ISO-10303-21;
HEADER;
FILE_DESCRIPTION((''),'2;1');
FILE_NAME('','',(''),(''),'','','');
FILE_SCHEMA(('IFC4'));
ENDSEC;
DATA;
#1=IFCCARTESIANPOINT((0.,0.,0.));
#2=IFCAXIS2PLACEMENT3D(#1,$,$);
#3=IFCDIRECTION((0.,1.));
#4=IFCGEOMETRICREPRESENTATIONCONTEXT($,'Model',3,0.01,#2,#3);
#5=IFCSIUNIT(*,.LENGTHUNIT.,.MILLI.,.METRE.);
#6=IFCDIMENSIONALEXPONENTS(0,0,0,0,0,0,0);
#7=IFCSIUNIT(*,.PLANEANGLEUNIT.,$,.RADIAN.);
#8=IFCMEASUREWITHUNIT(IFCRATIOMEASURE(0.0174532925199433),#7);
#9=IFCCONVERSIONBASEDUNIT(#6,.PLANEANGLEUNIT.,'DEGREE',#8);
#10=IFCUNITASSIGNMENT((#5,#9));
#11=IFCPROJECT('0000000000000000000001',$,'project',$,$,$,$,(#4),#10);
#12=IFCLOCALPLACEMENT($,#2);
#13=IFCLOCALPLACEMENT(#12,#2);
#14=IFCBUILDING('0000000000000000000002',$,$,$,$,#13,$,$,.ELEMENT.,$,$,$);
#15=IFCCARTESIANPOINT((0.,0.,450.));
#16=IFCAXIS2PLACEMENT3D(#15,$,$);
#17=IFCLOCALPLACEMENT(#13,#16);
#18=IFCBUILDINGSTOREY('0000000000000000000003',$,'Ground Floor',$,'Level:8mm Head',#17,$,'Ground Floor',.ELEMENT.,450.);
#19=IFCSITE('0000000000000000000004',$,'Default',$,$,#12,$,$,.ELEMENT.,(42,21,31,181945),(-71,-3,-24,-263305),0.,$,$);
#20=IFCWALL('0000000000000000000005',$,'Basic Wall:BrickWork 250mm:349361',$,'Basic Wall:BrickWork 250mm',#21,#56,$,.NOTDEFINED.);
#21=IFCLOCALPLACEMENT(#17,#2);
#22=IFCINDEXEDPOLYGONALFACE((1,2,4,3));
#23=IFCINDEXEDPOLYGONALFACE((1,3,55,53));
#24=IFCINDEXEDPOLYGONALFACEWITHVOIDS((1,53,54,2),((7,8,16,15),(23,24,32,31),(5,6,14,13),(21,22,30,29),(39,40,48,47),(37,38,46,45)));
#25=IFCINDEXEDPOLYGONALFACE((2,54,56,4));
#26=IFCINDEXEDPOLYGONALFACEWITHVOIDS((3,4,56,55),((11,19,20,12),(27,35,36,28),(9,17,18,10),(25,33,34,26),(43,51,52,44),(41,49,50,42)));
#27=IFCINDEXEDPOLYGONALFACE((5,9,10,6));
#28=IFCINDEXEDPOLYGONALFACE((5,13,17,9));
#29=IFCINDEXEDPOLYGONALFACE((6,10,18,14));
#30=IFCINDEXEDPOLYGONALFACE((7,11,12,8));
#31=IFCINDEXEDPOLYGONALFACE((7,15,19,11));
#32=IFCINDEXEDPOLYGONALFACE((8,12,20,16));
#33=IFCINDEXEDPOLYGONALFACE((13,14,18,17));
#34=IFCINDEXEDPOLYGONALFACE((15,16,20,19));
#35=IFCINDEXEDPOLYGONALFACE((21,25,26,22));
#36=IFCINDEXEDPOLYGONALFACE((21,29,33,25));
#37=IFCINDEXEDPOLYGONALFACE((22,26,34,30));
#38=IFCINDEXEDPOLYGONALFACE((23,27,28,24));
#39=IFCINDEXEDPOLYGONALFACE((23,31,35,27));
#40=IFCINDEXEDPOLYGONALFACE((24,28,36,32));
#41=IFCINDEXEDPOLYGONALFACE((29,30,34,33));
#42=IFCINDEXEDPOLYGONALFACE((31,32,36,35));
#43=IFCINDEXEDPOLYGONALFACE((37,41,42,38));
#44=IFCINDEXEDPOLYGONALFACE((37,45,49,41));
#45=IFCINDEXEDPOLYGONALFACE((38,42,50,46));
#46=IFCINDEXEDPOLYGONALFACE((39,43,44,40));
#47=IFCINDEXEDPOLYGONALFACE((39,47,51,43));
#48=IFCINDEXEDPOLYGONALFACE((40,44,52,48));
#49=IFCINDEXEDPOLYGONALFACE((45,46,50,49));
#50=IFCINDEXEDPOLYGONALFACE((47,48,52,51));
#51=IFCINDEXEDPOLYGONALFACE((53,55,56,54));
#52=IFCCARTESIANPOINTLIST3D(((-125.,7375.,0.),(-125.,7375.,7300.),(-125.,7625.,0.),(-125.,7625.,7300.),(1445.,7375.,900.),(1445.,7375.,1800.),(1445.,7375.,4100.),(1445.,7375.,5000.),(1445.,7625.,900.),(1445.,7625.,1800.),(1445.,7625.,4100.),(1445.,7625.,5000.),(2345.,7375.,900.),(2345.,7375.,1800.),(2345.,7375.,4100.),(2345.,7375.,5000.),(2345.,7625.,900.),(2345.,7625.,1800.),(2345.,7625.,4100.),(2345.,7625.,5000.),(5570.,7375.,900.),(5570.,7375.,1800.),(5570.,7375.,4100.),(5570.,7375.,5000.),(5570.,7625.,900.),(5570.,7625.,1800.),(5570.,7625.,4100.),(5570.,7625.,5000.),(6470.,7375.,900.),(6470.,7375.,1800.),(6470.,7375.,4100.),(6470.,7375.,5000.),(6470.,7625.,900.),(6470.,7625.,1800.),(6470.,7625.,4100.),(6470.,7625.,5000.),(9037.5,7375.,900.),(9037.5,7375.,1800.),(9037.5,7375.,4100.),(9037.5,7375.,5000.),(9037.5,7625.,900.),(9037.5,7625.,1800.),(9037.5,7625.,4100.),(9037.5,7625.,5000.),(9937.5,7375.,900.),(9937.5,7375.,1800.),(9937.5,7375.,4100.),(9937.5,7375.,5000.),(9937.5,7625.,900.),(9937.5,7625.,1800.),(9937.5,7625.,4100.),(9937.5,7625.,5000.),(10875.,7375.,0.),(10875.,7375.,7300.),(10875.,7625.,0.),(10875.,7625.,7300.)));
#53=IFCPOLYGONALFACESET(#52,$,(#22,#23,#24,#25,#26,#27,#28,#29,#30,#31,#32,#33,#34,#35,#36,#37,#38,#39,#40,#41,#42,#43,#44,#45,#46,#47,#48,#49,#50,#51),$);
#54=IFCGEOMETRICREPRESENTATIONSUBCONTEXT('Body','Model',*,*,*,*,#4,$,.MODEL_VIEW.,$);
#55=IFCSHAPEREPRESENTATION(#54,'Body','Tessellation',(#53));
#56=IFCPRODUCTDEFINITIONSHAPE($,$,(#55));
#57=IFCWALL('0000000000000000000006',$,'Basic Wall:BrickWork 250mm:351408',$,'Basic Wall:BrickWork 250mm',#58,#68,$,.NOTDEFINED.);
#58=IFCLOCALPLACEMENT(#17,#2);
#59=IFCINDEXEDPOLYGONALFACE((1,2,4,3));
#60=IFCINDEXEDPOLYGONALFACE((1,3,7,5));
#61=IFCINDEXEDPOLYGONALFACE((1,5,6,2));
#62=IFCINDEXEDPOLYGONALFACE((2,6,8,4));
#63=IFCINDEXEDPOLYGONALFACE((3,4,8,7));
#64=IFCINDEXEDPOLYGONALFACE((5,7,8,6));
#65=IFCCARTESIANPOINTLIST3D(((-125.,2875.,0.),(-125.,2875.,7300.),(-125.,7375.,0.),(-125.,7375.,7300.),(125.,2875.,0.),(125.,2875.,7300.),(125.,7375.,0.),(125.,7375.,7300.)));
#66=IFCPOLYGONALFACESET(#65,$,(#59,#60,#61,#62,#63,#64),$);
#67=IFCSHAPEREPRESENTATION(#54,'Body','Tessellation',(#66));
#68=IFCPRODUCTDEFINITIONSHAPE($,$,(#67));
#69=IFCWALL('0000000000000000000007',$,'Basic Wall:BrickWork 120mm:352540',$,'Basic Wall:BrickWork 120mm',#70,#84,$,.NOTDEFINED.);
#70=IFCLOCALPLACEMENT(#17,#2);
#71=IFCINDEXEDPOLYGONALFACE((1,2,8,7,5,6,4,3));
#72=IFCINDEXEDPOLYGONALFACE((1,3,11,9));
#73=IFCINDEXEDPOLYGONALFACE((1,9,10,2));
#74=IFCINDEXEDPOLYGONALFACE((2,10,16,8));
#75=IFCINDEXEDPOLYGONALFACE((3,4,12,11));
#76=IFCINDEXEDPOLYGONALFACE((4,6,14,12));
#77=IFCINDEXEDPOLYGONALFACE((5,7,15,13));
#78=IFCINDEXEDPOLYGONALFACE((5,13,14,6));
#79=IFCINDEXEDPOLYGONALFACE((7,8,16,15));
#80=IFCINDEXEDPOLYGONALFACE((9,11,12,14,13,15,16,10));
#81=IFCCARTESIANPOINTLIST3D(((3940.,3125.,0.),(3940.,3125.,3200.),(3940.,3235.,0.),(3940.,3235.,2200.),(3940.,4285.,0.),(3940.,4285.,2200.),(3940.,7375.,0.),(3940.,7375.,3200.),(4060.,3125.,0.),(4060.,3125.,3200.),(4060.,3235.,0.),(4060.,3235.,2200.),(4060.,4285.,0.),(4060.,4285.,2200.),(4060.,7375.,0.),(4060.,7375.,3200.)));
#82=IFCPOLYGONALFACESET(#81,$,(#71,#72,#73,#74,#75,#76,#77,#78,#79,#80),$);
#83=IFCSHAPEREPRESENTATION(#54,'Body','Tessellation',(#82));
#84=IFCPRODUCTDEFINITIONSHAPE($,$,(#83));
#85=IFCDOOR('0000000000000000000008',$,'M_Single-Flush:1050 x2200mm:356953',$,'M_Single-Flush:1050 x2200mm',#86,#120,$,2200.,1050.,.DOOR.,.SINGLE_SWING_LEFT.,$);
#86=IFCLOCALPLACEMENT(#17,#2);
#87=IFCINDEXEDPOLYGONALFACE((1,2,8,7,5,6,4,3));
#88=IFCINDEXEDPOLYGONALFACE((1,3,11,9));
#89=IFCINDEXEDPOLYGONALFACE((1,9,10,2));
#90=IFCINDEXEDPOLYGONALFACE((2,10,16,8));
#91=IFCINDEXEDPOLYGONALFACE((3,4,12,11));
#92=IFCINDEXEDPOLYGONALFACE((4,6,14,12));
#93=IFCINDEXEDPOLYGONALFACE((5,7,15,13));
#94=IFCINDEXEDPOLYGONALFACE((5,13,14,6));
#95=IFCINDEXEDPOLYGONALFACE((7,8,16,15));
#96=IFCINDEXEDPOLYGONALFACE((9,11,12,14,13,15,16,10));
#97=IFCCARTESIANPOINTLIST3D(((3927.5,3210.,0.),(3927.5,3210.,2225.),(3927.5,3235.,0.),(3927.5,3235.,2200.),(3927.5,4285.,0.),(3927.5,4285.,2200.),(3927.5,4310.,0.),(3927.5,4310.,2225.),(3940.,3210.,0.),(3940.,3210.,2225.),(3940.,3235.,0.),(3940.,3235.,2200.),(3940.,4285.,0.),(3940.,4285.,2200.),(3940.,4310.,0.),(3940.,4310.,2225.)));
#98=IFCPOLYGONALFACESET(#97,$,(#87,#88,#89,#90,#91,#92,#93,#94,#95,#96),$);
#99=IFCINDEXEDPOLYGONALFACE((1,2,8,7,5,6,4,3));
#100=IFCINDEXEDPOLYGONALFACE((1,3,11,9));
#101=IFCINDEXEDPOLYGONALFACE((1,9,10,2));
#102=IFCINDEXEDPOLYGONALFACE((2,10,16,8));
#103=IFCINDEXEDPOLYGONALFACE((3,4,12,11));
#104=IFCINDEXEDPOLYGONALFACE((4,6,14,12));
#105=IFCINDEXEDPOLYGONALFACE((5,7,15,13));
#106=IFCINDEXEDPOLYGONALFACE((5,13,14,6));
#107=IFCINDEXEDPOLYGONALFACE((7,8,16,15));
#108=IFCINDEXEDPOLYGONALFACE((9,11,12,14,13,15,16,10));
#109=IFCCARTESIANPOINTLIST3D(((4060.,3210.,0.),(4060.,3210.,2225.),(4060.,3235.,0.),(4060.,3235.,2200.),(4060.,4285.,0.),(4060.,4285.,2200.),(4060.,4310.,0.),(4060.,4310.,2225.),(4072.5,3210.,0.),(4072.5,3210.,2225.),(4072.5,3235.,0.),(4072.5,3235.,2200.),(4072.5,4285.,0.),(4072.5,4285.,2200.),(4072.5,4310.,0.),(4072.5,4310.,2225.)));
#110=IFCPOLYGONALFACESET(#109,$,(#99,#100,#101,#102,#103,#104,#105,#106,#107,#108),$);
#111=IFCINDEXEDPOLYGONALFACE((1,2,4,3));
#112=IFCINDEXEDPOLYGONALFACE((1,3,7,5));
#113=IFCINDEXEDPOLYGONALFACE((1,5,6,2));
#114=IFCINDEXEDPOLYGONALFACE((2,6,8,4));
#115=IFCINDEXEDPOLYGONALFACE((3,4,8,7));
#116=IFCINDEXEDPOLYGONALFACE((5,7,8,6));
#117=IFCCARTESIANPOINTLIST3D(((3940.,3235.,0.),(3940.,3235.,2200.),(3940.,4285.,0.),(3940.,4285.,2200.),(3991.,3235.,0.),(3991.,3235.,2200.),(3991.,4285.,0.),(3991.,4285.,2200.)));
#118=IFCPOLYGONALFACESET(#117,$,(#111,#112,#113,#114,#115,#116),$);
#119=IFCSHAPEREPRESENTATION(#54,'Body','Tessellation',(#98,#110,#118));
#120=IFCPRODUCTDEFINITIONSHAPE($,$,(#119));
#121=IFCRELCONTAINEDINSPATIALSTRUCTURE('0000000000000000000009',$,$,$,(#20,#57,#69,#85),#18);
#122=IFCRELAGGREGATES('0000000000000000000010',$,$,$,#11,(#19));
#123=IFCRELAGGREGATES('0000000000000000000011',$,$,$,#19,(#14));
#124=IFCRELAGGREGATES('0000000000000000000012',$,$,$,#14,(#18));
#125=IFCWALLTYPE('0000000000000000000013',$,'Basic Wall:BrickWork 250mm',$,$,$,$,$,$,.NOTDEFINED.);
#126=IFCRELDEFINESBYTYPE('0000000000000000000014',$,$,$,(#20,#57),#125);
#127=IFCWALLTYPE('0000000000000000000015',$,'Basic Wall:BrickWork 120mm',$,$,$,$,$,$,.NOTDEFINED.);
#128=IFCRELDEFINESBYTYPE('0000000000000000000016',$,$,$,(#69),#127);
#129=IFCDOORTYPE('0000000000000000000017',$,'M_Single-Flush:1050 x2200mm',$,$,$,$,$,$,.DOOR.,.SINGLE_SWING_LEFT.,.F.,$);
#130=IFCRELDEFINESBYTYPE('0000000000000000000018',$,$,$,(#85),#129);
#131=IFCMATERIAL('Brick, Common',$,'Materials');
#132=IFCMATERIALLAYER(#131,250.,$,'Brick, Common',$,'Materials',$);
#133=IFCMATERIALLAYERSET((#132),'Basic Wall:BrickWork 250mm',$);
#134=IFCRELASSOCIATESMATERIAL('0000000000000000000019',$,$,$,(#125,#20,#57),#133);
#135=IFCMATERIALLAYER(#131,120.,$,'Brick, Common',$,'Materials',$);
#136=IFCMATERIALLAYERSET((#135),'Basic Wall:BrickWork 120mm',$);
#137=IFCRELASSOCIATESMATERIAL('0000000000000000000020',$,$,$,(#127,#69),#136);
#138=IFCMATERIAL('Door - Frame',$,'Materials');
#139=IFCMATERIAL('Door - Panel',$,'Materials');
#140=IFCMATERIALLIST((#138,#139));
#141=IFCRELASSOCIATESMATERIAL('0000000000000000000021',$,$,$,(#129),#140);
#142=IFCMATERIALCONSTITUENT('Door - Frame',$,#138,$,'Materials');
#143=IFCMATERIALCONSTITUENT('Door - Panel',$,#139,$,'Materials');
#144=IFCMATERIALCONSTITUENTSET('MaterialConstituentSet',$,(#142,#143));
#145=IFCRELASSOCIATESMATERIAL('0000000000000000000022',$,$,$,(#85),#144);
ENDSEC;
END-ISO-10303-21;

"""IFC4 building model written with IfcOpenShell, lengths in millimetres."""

from ifc_helpers import new_model, entity, si_unit, converted_unit, direction, frame, frame_2d, origin, place, context, subcontext, project, spatial, polyline, rectangle, outline, extrude, source, transform, mapped, material, material_list, layer, layer_set, layer_usage, constituent, constituent_set, type_object, type_shapes, element, fill, save


model = new_model("IFC4")

# Units and contexts
model_context = context("Model", 3, precision=0.01, world=origin(), true_north=direction((0.0, 1.0)))
body_context = subcontext(model_context, "Body", "Model", "MODEL_VIEW")
ifc_project = project(units=[si_unit("LENGTHUNIT", "METRE", prefix="MILLI"), converted_unit("PLANEANGLEUNIT", "DEGREE", entity("IfcRatioMeasure", 0.0174532925199433), si_unit("PLANEANGLEUNIT", "RADIAN"), dimensions=[0, 0, 0, 0, 0, 0, 0])], contexts=[model_context])

# Site, building, storey
site_placement = place(None, origin())
site = spatial("IfcSite", under=ifc_project, at=site_placement, Name="Default", CompositionType="ELEMENT", RefLatitude=(42, 21, 31, 181945), RefLongitude=(-71, -3, -24, -263305), RefElevation=0.0)
building_placement = place(site_placement, origin())
building = spatial("IfcBuilding", under=site, at=building_placement, CompositionType="ELEMENT")
storey_placement = place(building_placement, frame((0.0, 0.0, 450.0)))
storey = spatial("IfcBuildingStorey", under=building, at=storey_placement, Name="Ground Floor", ObjectType="Level:8mm Head", LongName="Ground Floor", CompositionType="ELEMENT", Elevation=450.0)

# Wall, openings
ifc_material_1 = material(Name="Brick, Common", Category="Materials")
ifc_layer_1 = layer(ifc_material_1, 250.0, Name="Brick, Common", Category="Materials")
ifc_layer_set_1 = layer_set([ifc_layer_1], Name="Basic Wall:BrickWork 250mm")
ifc_layer_usage_1 = layer_usage(ifc_layer_set_1, "AXIS2", "POSITIVE", -125.0)
wall_type_1 = type_object("IfcWallType", Name="Basic Wall:BrickWork 250mm", PredefinedType="NOTDEFINED", material=ifc_layer_set_1)
wall_1_placement = place(storey_placement, frame((-125.0, 7500.0, 0.0)))
wall_1 = element("IfcWall", 1, at=wall_1_placement, inside=storey, type_object=wall_type_1, material=ifc_layer_usage_1, Name="Basic Wall:BrickWork 250mm:349361", ObjectType="Basic Wall:BrickWork 250mm", PredefinedType="NOTDEFINED", context=body_context, shape_type="SweptSolid", body=[
    extrude(rectangle(XDim=11000.0, YDim=250.0, at=frame_2d((5500.0, 0.0), x_axis=(-1.0, 0.0))), origin(), (0.0, 0.0, 1.0), 7300.0),
])
opening_1_placement = place(wall_1_placement, frame((2470.0, 125.0, 900.0)))
element("IfcOpeningElement", 2, at=opening_1_placement, cuts=wall_1, ObjectType="Opening", PredefinedType="OPENING", context=body_context, shape_type="SweptSolid", body=[
    extrude(rectangle(XDim=900.0, YDim=900.0, at=frame_2d((450.0, 450.0), x_axis=(-1.0, 0.0))), frame((0.0, 0.0, 0.0), z_axis=(0.0, -1.0, 0.0), x_axis=(0.0, 0.0, 1.0)), (0.0, 0.0, 1.0), 250.0),
])
opening_2_placement = place(wall_1_placement, frame((6595.0, 125.0, 900.0)))
element("IfcOpeningElement", 3, at=opening_2_placement, cuts=wall_1, ObjectType="Opening", PredefinedType="OPENING", context=body_context, shape_type="SweptSolid", body=[
    extrude(rectangle(XDim=900.0, YDim=900.0, at=frame_2d((450.0, 450.0), x_axis=(-1.0, 0.0))), frame((0.0, 0.0, 0.0), z_axis=(0.0, -1.0, 0.0), x_axis=(0.0, 0.0, 1.0)), (0.0, 0.0, 1.0), 250.0),
])
opening_3_placement = place(wall_1_placement, frame((10062.5, 125.0, 900.0)))
element("IfcOpeningElement", 4, at=opening_3_placement, cuts=wall_1, ObjectType="Opening", PredefinedType="OPENING", context=body_context, shape_type="SweptSolid", body=[
    extrude(rectangle(XDim=900.0, YDim=900.0, at=frame_2d((450.0, 450.0), x_axis=(-1.0, 0.0))), frame((0.0, 0.0, 0.0), z_axis=(0.0, -1.0, 0.0), x_axis=(0.0, 0.0, 1.0)), (0.0, 0.0, 1.0), 250.0),
])
opening_4_placement = place(wall_1_placement, frame((2470.0, 125.0, 4100.0)))
element("IfcOpeningElement", 5, at=opening_4_placement, cuts=wall_1, ObjectType="Opening", PredefinedType="OPENING", context=body_context, shape_type="SweptSolid", body=[
    extrude(rectangle(XDim=900.0, YDim=900.0, at=frame_2d((450.0, 450.0), x_axis=(-1.0, 0.0))), frame((0.0, 0.0, 0.0), z_axis=(0.0, -1.0, 0.0), x_axis=(0.0, 0.0, 1.0)), (0.0, 0.0, 1.0), 250.0),
])
opening_5_placement = place(wall_1_placement, frame((6595.0, 125.0, 4100.0)))
element("IfcOpeningElement", 6, at=opening_5_placement, cuts=wall_1, ObjectType="Opening", PredefinedType="OPENING", context=body_context, shape_type="SweptSolid", body=[
    extrude(rectangle(XDim=900.0, YDim=900.0, at=frame_2d((450.0, 450.0), x_axis=(-1.0, 0.0))), frame((0.0, 0.0, 0.0), z_axis=(0.0, -1.0, 0.0), x_axis=(0.0, 0.0, 1.0)), (0.0, 0.0, 1.0), 250.0),
])
opening_6_placement = place(wall_1_placement, frame((10062.5, 125.0, 4100.0)))
element("IfcOpeningElement", 7, at=opening_6_placement, cuts=wall_1, ObjectType="Opening", PredefinedType="OPENING", context=body_context, shape_type="SweptSolid", body=[
    extrude(rectangle(XDim=900.0, YDim=900.0, at=frame_2d((450.0, 450.0), x_axis=(-1.0, 0.0))), frame((0.0, 0.0, 0.0), z_axis=(0.0, -1.0, 0.0), x_axis=(0.0, 0.0, 1.0)), (0.0, 0.0, 1.0), 250.0),
])

# Wall
ifc_layer_usage_2 = layer_usage(ifc_layer_set_1, "AXIS2", "POSITIVE", -125.0)
wall_2_placement = place(storey_placement, frame((0.0, 7375.0, 0.0), z_axis=(0.0, 0.0, 1.0), x_axis=(0.0, -1.0, 0.0)))
element("IfcWall", 8, at=wall_2_placement, inside=storey, type_object=wall_type_1, material=ifc_layer_usage_2, Name="Basic Wall:BrickWork 250mm:351408", ObjectType="Basic Wall:BrickWork 250mm", PredefinedType="NOTDEFINED", context=body_context, shape_type="SweptSolid", body=[
    extrude(rectangle(XDim=4500.0, YDim=250.0, at=frame_2d((2250.0, 0.0), x_axis=(-1.0, 0.0))), origin(), (0.0, 0.0, 1.0), 7300.0),
])

# Wall, opening, door
ifc_layer_2 = layer(ifc_material_1, 120.0, Name="Brick, Common", Category="Materials")
ifc_layer_set_2 = layer_set([ifc_layer_2], Name="Basic Wall:BrickWork 120mm")
ifc_layer_usage_3 = layer_usage(ifc_layer_set_2, "AXIS2", "NEGATIVE", 60.0)
wall_type_2 = type_object("IfcWallType", Name="Basic Wall:BrickWork 120mm", PredefinedType="NOTDEFINED", material=ifc_layer_set_2)
wall_3_placement = place(storey_placement, frame((4000.0, 7375.0, 0.0), z_axis=(0.0, 0.0, 1.0), x_axis=(0.0, -1.0, 0.0)))
wall_3 = element("IfcWall", 9, at=wall_3_placement, inside=storey, type_object=wall_type_2, material=ifc_layer_usage_3, Name="Basic Wall:BrickWork 120mm:352540", ObjectType="Basic Wall:BrickWork 120mm", PredefinedType="NOTDEFINED", context=body_context, shape_type="SweptSolid", body=[
    extrude(rectangle(XDim=4250.0, YDim=120.0, at=frame_2d((2125.0, 0.0), x_axis=(-1.0, 0.0))), origin(), (0.0, 0.0, 1.0), 3200.0),
])
opening_7_placement = place(wall_3_placement, frame((4140.0, 60.0, 0.0)))
opening_7 = element("IfcOpeningElement", 10, at=opening_7_placement, cuts=wall_3, ObjectType="Opening", PredefinedType="OPENING", context=body_context, shape_type="SweptSolid", body=[
    extrude(rectangle(XDim=1050.0, YDim=2200.0, at=frame_2d((1100.0, 525.0), x_axis=(0.0, -1.0))), frame((0.0, 0.0, 0.0), z_axis=(0.0, -1.0, 0.0), x_axis=(0.0, 0.0, 1.0)), (0.0, 0.0, 1.0), 120.0),
])
ifc_material_2 = material(Name="Door - Frame", Category="Materials")
ifc_constituent_1 = constituent(ifc_material_2, Name="Door - Frame", Category="Materials")
ifc_material_3 = material(Name="Door - Panel", Category="Materials")
ifc_constituent_2 = constituent(ifc_material_3, Name="Door - Panel", Category="Materials")
ifc_constituent_set_1 = constituent_set(constituents=[ifc_constituent_1, ifc_constituent_2], Name="MaterialConstituentSet")
ifc_material_list_1 = material_list([ifc_material_2, ifc_material_3])
door_type = type_object("IfcDoorType", Name="M_Single-Flush:1050 x2200mm", OperationType="SINGLE_SWING_LEFT", ParameterTakesPrecedence=False, PredefinedType="DOOR", material=ifc_material_list_1)
shared_shape_1 = source(origin(), body_context, "Body", "SweptSolid", [
    extrude(outline(polyline([(-550.0, -1118.8), (550.0, -1118.8), (550.0, 1106.2), (525.0, 1106.2), (525.0, -1093.8), (-525.0, -1093.8), (-525.0, 1106.2), (-550.0, 1106.2), (-550.0, -1118.8)])), frame((525.0, 132.5, 1106.2), z_axis=(0.0, -1.0, 0.0), x_axis=(-1.0, 0.0, 0.0)), (0.0, 0.0, 1.0), 12.5),
    extrude(outline(polyline([(-1118.8, -550.0), (1106.2, -550.0), (1106.2, -525.0), (-1093.8, -525.0), (-1093.8, 525.0), (1106.2, 525.0), (1106.2, 550.0), (-1118.8, 550.0), (-1118.8, -550.0)])), frame((525.0, 0.0, 1106.2), z_axis=(0.0, -1.0, 0.0), x_axis=(0.0, 0.0, -1.0)), (0.0, 0.0, 1.0), 12.5),
    extrude(rectangle(XDim=1050.0, YDim=51.0, at=frame_2d((0.0, 0.0), x_axis=(1.0, 0.0))), frame((525.0, 94.5, 0.0)), (0.0, 0.0, 1.0), 2200.0),
])
type_shapes(door_type, [shared_shape_1])
door_placement = place(opening_7_placement, frame((0.0, 0.0, 0.0), z_axis=(0.0, 0.0, 1.0), x_axis=(-1.0, 0.0, 0.0)))
door = element("IfcDoor", 11, at=door_placement, inside=storey, type_object=door_type, material=ifc_constituent_set_1, Name="M_Single-Flush:1050 x2200mm:356953", ObjectType="M_Single-Flush:1050 x2200mm", OperationType="SINGLE_SWING_LEFT", OverallHeight=2200.0, OverallWidth=1050.0, PredefinedType="DOOR", context=body_context, shape_type="MappedRepresentation", body=[
    mapped(shared_shape_1, transform((0.0, 0.0, 0.0), scale=1.0)),
])
fill(opening_7, door)

save(model, "model.ifc")
